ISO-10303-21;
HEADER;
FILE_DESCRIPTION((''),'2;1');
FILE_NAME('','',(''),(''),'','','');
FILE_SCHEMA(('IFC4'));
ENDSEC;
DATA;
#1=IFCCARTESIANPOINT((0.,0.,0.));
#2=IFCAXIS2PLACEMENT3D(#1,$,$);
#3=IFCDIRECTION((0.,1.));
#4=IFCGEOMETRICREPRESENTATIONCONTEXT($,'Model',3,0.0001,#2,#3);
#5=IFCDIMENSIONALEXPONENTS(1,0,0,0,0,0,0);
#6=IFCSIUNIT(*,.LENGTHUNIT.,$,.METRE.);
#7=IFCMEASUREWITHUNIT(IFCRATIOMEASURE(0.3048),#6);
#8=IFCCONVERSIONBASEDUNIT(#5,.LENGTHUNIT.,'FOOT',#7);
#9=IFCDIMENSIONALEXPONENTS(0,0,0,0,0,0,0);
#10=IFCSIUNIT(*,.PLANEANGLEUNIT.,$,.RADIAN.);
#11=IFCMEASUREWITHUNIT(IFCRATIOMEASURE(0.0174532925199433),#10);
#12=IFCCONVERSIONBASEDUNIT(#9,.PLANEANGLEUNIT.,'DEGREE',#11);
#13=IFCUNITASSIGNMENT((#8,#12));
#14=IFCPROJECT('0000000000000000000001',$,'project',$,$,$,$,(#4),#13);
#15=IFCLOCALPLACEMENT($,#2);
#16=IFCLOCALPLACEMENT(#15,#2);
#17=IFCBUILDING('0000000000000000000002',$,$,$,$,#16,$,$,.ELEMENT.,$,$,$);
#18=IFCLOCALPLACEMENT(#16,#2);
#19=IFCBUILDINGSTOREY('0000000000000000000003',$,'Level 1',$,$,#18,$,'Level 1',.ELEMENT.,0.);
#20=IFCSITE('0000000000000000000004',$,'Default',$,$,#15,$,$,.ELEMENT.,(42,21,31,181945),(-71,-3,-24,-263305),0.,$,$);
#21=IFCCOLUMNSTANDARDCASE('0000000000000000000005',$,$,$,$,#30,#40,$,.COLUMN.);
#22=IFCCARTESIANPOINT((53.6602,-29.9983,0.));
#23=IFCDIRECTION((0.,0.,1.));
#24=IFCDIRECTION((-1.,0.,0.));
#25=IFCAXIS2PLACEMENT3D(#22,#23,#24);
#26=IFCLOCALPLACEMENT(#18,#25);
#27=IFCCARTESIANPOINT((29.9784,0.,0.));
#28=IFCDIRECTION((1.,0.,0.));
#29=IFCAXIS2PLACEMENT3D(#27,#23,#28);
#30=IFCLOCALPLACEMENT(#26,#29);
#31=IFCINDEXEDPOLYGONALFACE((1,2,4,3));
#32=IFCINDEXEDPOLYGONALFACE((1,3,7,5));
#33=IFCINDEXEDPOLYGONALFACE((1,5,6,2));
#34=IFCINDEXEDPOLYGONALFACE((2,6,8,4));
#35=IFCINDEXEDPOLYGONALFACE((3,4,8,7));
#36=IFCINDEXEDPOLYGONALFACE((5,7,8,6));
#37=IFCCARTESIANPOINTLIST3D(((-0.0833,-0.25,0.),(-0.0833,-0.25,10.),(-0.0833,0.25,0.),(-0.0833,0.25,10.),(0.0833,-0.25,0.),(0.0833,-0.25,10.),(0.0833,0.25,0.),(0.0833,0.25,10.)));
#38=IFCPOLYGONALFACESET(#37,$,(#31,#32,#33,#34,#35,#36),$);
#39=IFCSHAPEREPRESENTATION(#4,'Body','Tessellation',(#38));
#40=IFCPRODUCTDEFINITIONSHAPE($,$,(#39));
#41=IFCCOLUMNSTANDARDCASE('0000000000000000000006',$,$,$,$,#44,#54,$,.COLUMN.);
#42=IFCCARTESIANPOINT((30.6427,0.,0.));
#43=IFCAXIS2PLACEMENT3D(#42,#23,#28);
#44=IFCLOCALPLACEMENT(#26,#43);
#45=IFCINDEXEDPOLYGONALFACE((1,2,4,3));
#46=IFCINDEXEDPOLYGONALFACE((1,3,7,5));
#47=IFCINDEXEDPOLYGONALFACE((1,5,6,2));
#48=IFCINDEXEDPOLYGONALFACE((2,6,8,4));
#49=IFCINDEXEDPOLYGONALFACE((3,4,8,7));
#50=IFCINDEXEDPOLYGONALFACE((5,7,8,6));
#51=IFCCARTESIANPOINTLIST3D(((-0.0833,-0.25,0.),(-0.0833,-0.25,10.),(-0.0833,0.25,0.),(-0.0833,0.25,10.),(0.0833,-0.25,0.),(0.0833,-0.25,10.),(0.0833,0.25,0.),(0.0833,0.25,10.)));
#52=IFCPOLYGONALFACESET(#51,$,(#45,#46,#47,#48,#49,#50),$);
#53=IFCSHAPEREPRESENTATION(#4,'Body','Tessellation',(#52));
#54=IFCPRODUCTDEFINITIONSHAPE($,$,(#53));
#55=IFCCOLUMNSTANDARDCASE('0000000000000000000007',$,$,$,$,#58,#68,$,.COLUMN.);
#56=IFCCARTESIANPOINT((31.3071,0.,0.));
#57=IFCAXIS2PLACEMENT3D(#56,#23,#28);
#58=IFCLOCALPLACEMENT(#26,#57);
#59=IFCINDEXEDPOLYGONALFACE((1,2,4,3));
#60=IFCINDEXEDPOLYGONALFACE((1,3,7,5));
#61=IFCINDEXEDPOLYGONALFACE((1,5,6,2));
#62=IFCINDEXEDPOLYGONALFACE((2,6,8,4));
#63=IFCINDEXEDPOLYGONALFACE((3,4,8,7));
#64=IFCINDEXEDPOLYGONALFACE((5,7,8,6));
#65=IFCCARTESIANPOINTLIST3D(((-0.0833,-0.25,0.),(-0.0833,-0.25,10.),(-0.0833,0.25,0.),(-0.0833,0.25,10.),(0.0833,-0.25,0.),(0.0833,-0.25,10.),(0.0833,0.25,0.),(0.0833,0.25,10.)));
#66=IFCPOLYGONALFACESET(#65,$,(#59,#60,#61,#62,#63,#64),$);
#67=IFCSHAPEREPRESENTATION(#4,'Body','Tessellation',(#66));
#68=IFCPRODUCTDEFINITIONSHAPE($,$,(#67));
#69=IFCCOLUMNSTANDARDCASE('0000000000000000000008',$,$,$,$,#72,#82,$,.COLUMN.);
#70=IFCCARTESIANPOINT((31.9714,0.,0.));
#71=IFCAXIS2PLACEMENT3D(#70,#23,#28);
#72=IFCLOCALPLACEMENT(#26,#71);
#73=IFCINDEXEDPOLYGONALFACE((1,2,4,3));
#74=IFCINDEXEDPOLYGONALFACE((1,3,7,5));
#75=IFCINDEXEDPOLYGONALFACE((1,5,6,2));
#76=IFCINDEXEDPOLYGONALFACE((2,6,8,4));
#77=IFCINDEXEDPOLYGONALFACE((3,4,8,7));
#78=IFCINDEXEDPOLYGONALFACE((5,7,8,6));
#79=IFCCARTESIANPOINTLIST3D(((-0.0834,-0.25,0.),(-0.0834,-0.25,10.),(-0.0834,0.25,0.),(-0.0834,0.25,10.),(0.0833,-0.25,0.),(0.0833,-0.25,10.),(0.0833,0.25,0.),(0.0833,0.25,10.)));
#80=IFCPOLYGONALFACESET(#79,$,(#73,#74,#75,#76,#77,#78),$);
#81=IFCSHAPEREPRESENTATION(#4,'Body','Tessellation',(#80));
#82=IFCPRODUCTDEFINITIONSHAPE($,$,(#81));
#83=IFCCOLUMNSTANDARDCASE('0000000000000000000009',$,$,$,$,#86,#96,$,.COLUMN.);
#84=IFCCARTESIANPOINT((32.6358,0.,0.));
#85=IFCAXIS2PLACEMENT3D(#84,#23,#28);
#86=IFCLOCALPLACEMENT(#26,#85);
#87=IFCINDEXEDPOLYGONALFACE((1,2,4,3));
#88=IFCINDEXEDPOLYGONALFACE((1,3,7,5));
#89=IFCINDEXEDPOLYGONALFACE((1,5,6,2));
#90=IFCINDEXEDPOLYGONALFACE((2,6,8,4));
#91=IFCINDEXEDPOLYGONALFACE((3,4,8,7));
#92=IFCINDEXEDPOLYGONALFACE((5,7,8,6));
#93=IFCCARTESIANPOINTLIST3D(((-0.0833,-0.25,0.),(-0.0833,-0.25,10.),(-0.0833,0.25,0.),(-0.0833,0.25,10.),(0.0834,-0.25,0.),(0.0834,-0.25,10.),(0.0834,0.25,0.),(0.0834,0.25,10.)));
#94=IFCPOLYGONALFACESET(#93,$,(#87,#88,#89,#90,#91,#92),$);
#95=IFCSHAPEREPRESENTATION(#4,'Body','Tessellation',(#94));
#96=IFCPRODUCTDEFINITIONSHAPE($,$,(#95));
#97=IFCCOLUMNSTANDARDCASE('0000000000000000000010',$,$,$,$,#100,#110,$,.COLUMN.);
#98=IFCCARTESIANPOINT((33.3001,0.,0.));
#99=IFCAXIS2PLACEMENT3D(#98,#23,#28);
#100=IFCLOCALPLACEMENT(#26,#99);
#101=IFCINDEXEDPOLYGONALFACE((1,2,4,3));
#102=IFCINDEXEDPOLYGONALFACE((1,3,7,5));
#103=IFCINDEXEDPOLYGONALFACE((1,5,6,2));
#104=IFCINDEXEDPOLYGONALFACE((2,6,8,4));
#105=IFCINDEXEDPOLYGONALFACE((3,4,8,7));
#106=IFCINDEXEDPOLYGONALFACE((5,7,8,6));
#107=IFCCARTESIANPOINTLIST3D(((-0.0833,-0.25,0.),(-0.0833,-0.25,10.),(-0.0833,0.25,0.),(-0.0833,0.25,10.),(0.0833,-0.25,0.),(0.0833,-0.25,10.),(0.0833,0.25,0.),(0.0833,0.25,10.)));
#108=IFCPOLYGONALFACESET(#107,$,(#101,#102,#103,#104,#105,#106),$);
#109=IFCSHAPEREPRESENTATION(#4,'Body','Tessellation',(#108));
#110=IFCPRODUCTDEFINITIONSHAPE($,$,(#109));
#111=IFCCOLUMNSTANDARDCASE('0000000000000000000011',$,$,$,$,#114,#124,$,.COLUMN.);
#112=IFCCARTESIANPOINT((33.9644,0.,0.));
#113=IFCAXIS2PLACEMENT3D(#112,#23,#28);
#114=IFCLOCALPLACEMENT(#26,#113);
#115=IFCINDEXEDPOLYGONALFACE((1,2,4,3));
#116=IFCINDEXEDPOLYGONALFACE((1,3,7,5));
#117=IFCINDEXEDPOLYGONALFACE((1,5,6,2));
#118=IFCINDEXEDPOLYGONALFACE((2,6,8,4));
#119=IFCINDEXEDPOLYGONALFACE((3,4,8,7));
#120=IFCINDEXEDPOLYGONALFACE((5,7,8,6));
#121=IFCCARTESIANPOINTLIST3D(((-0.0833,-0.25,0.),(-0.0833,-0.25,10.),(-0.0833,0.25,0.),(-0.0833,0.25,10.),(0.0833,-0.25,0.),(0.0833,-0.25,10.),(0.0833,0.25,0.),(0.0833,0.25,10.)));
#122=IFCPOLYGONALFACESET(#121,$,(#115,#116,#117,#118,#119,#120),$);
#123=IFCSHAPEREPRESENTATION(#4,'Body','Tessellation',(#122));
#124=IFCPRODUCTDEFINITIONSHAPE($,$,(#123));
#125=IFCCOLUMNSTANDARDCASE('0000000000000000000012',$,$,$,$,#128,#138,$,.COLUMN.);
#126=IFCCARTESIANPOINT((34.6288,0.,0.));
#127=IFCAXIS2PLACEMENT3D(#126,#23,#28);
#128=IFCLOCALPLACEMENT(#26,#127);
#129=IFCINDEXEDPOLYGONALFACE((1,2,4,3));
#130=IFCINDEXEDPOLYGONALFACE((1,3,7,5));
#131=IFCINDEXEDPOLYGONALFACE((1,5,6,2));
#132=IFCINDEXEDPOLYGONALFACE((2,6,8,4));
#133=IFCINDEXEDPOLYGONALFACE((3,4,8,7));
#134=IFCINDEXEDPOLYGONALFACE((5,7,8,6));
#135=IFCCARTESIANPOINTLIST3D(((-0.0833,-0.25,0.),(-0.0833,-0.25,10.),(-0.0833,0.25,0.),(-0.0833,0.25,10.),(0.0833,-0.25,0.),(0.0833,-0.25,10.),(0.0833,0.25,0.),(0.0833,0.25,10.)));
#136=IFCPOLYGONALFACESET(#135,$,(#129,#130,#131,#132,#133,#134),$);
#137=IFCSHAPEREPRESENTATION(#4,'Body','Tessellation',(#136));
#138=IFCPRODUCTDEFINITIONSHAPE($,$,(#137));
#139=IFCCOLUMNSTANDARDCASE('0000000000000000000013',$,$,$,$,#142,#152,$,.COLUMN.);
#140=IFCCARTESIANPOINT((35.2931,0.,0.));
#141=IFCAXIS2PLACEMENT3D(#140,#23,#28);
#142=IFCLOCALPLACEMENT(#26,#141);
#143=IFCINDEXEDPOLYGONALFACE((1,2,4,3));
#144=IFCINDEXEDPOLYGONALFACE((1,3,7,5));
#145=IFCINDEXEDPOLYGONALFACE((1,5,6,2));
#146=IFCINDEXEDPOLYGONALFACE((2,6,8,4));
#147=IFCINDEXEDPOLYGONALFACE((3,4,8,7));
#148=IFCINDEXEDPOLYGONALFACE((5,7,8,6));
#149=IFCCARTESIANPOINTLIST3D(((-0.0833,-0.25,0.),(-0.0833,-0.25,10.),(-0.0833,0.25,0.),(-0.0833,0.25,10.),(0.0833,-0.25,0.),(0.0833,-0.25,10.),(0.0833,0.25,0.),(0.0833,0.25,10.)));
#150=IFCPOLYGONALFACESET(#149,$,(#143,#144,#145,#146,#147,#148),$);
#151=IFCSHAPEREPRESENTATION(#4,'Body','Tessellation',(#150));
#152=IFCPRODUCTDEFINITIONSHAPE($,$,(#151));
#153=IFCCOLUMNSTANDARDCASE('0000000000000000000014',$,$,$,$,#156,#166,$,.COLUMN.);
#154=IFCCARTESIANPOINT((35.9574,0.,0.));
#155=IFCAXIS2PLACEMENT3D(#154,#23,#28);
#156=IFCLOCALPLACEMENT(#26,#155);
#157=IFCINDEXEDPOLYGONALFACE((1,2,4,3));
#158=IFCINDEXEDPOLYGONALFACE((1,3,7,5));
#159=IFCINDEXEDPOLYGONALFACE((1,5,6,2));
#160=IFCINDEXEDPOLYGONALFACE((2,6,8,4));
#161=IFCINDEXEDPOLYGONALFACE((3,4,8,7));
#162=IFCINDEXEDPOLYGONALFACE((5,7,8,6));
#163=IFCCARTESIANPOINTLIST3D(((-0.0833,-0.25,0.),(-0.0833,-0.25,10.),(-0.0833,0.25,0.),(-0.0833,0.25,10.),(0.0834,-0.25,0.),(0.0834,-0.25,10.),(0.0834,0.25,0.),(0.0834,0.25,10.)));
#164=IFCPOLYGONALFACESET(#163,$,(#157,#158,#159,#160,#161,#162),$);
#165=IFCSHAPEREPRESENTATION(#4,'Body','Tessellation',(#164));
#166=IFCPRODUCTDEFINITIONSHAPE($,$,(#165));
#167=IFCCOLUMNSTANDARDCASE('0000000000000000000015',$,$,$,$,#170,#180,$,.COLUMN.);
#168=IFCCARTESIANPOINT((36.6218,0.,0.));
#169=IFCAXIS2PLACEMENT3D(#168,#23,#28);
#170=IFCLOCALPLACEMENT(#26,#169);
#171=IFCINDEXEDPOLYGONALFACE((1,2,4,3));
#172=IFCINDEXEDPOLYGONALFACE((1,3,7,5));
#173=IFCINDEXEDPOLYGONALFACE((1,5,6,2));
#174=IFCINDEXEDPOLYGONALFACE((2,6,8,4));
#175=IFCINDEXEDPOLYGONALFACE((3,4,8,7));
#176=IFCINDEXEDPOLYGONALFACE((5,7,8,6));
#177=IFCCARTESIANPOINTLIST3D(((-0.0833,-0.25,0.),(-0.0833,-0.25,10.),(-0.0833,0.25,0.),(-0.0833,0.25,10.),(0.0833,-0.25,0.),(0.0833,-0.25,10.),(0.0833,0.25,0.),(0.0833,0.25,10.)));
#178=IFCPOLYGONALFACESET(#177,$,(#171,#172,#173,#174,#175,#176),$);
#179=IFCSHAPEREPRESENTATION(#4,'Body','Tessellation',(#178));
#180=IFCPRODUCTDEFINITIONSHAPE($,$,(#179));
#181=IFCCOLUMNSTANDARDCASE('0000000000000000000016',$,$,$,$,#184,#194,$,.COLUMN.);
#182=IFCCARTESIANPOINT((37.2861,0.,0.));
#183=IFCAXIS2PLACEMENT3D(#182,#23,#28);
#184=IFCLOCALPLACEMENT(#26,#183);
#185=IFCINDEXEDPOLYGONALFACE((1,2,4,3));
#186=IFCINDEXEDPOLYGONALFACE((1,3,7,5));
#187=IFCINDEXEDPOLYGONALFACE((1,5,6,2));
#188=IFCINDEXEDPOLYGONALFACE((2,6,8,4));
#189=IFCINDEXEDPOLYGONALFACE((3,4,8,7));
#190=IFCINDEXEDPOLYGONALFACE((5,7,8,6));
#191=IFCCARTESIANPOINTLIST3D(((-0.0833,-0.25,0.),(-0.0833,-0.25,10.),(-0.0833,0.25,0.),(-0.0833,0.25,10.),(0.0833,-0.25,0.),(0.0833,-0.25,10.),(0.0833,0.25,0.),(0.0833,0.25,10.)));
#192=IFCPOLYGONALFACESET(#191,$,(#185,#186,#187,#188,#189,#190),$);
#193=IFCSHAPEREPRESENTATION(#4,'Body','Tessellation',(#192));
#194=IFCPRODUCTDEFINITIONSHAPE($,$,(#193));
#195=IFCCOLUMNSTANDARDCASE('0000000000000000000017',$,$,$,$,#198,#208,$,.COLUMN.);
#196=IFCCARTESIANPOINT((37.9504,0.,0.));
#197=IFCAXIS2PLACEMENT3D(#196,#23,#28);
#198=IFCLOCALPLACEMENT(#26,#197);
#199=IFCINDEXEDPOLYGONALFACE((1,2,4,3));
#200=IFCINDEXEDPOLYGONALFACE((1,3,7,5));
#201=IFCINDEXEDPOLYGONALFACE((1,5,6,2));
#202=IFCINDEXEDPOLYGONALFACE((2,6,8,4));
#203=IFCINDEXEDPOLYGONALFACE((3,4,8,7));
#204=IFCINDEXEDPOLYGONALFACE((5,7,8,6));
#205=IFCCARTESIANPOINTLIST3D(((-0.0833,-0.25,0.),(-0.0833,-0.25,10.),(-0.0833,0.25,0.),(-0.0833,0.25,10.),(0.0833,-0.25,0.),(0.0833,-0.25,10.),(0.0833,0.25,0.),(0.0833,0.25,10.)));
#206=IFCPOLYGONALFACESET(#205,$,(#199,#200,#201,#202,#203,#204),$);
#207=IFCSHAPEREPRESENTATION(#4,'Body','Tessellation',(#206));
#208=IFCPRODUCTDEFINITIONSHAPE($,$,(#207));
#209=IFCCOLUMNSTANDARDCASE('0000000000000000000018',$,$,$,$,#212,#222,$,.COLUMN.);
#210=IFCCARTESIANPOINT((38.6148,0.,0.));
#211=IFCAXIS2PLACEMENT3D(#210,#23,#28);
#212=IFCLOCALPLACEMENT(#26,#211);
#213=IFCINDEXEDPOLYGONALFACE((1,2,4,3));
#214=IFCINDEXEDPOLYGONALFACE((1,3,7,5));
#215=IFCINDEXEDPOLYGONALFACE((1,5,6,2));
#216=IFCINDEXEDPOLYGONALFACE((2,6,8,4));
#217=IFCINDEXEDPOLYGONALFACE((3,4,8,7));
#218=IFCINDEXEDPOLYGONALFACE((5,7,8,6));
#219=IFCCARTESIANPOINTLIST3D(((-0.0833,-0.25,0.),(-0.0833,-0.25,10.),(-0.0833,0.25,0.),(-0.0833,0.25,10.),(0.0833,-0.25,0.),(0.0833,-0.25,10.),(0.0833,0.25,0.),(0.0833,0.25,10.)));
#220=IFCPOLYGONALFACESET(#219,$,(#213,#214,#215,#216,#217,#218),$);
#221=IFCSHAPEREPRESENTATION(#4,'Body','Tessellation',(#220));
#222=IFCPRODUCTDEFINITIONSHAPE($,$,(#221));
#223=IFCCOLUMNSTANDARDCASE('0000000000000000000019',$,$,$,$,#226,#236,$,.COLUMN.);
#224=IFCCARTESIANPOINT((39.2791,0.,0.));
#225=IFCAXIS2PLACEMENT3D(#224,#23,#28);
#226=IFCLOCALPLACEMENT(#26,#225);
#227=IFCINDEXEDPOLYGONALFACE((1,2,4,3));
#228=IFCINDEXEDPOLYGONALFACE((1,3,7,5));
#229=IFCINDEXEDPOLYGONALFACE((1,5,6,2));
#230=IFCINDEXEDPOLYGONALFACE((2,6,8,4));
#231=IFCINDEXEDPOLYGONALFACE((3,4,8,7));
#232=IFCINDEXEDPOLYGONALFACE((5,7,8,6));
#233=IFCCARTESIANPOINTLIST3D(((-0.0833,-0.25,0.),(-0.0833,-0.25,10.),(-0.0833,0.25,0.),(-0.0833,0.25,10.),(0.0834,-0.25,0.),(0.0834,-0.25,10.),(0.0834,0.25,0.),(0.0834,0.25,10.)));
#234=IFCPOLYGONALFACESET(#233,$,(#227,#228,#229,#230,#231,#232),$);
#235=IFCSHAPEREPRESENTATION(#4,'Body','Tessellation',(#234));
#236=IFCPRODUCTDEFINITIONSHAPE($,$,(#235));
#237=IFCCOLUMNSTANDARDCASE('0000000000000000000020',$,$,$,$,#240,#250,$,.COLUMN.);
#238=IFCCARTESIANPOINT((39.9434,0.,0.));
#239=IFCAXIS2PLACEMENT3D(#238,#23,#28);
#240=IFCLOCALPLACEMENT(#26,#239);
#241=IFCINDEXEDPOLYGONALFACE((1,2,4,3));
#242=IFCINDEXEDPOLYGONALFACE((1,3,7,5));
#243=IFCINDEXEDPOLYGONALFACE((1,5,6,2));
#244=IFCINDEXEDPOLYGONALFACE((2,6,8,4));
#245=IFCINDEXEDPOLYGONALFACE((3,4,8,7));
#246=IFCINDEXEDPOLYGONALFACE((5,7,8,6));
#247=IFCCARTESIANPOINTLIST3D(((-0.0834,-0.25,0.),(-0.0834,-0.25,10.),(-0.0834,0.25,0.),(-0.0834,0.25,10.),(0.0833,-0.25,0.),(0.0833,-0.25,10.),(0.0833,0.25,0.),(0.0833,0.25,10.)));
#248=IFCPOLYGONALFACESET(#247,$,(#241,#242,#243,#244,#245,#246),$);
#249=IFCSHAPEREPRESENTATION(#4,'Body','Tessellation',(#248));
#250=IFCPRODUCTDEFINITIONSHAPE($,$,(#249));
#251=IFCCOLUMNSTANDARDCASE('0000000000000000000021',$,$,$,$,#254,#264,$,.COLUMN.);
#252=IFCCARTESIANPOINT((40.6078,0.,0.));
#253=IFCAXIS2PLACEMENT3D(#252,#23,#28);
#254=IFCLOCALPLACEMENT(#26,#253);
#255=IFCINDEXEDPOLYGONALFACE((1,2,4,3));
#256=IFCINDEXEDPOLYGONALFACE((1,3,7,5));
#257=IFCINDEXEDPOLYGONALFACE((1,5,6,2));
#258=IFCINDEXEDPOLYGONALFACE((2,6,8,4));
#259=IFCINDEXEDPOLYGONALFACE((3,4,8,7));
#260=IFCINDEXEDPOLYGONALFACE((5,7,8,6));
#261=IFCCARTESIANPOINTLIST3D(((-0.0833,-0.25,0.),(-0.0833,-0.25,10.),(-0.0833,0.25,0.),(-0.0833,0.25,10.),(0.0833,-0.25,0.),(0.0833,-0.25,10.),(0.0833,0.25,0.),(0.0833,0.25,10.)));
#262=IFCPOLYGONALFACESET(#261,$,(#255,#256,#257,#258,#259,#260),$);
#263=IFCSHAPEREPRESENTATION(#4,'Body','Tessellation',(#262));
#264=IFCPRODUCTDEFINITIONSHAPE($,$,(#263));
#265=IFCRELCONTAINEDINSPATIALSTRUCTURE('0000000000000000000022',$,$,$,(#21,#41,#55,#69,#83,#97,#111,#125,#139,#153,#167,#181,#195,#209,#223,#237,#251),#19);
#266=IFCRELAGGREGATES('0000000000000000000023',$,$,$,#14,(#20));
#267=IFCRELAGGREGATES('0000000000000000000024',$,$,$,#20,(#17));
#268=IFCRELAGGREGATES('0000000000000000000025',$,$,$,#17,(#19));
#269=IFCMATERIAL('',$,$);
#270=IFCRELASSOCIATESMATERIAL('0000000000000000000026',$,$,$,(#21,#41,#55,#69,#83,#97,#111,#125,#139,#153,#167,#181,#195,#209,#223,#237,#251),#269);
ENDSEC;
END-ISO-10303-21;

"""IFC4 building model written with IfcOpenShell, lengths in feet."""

from ifc_helpers import new_model, entity, si_unit, converted_unit, direction, frame, origin, place, context, project, spatial, rectangle, extrude, material, element, save


model = new_model("IFC4")

# Units and contexts
model_context = context("Model", 3, precision=0.0001, world=origin(), true_north=direction((0.0, 1.0)))
ifc_project = project(units=[converted_unit("LENGTHUNIT", "FOOT", entity("IfcRatioMeasure", 0.3048), si_unit("LENGTHUNIT", "METRE"), dimensions=[1, 0, 0, 0, 0, 0, 0]), converted_unit("PLANEANGLEUNIT", "DEGREE", entity("IfcRatioMeasure", 0.0174532925199433), si_unit("PLANEANGLEUNIT", "RADIAN"), dimensions=[0, 0, 0, 0, 0, 0, 0])], contexts=[model_context])

# Site, building, storey
site_placement = place(None, origin())
site = spatial("IfcSite", under=ifc_project, at=site_placement, Name="Default", CompositionType="ELEMENT", RefLatitude=(42, 21, 31, 181945), RefLongitude=(-71, -3, -24, -263305), RefElevation=0.0)
building_placement = place(site_placement, origin())
building = spatial("IfcBuilding", under=site, at=building_placement, CompositionType="ELEMENT")
storey_placement = place(building_placement, origin())
storey = spatial("IfcBuildingStorey", under=building, at=storey_placement, Name="Level 1", LongName="Level 1", CompositionType="ELEMENT", Elevation=0.0)

# Columns
ifc_material = material(Name="")
placement = place(storey_placement, frame((53.6602, -29.9983, 0.0), z_axis=(0.0, 0.0, 1.0), x_axis=(-1.0, 0.0, 0.0)))
for number, where, z_axis, x_axis in (
    (1, (29.9784, 0.0, 0.0), (0.0, 0.0, 1.0), (1.0, 0.0, 0.0)),
    (2, (30.6427, 0.0, 0.0), (0.0, 0.0, 1.0), (1.0, 0.0, 0.0)),
    (3, (31.3071, 0.0, 0.0), (0.0, 0.0, 1.0), (1.0, 0.0, 0.0)),
    (4, (31.9714, 0.0, 0.0), (0.0, 0.0, 1.0), (1.0, 0.0, 0.0)),
    (5, (32.6358, 0.0, 0.0), (0.0, 0.0, 1.0), (1.0, 0.0, 0.0)),
    (6, (33.3001, 0.0, 0.0), (0.0, 0.0, 1.0), (1.0, 0.0, 0.0)),
    (7, (33.9644, 0.0, 0.0), (0.0, 0.0, 1.0), (1.0, 0.0, 0.0)),
    (8, (34.6288, 0.0, 0.0), (0.0, 0.0, 1.0), (1.0, 0.0, 0.0)),
    (9, (35.2931, 0.0, 0.0), (0.0, 0.0, 1.0), (1.0, 0.0, 0.0)),
    (10, (35.9574, 0.0, 0.0), (0.0, 0.0, 1.0), (1.0, 0.0, 0.0)),
    (11, (36.6218, 0.0, 0.0), (0.0, 0.0, 1.0), (1.0, 0.0, 0.0)),
    (12, (37.2861, 0.0, 0.0), (0.0, 0.0, 1.0), (1.0, 0.0, 0.0)),
    (13, (37.9504, 0.0, 0.0), (0.0, 0.0, 1.0), (1.0, 0.0, 0.0)),
    (14, (38.6148, 0.0, 0.0), (0.0, 0.0, 1.0), (1.0, 0.0, 0.0)),
    (15, (39.2791, 0.0, 0.0), (0.0, 0.0, 1.0), (1.0, 0.0, 0.0)),
    (16, (39.9434, 0.0, 0.0), (0.0, 0.0, 1.0), (1.0, 0.0, 0.0)),
    (17, (40.6078, 0.0, 0.0), (0.0, 0.0, 1.0), (1.0, 0.0, 0.0)),
):
    element("IfcColumnStandardCase", number, at=place(placement, frame(where, z_axis=z_axis, x_axis=x_axis)), inside=storey, material=ifc_material, PredefinedType="COLUMN", context=model_context, shape_type="SweptSolid", body=[
        extrude(rectangle(XDim=0.1667, YDim=0.5), origin(), (0.0, 0.0, 1.0), 10.0),
    ])

save(model, "model.ifc")
